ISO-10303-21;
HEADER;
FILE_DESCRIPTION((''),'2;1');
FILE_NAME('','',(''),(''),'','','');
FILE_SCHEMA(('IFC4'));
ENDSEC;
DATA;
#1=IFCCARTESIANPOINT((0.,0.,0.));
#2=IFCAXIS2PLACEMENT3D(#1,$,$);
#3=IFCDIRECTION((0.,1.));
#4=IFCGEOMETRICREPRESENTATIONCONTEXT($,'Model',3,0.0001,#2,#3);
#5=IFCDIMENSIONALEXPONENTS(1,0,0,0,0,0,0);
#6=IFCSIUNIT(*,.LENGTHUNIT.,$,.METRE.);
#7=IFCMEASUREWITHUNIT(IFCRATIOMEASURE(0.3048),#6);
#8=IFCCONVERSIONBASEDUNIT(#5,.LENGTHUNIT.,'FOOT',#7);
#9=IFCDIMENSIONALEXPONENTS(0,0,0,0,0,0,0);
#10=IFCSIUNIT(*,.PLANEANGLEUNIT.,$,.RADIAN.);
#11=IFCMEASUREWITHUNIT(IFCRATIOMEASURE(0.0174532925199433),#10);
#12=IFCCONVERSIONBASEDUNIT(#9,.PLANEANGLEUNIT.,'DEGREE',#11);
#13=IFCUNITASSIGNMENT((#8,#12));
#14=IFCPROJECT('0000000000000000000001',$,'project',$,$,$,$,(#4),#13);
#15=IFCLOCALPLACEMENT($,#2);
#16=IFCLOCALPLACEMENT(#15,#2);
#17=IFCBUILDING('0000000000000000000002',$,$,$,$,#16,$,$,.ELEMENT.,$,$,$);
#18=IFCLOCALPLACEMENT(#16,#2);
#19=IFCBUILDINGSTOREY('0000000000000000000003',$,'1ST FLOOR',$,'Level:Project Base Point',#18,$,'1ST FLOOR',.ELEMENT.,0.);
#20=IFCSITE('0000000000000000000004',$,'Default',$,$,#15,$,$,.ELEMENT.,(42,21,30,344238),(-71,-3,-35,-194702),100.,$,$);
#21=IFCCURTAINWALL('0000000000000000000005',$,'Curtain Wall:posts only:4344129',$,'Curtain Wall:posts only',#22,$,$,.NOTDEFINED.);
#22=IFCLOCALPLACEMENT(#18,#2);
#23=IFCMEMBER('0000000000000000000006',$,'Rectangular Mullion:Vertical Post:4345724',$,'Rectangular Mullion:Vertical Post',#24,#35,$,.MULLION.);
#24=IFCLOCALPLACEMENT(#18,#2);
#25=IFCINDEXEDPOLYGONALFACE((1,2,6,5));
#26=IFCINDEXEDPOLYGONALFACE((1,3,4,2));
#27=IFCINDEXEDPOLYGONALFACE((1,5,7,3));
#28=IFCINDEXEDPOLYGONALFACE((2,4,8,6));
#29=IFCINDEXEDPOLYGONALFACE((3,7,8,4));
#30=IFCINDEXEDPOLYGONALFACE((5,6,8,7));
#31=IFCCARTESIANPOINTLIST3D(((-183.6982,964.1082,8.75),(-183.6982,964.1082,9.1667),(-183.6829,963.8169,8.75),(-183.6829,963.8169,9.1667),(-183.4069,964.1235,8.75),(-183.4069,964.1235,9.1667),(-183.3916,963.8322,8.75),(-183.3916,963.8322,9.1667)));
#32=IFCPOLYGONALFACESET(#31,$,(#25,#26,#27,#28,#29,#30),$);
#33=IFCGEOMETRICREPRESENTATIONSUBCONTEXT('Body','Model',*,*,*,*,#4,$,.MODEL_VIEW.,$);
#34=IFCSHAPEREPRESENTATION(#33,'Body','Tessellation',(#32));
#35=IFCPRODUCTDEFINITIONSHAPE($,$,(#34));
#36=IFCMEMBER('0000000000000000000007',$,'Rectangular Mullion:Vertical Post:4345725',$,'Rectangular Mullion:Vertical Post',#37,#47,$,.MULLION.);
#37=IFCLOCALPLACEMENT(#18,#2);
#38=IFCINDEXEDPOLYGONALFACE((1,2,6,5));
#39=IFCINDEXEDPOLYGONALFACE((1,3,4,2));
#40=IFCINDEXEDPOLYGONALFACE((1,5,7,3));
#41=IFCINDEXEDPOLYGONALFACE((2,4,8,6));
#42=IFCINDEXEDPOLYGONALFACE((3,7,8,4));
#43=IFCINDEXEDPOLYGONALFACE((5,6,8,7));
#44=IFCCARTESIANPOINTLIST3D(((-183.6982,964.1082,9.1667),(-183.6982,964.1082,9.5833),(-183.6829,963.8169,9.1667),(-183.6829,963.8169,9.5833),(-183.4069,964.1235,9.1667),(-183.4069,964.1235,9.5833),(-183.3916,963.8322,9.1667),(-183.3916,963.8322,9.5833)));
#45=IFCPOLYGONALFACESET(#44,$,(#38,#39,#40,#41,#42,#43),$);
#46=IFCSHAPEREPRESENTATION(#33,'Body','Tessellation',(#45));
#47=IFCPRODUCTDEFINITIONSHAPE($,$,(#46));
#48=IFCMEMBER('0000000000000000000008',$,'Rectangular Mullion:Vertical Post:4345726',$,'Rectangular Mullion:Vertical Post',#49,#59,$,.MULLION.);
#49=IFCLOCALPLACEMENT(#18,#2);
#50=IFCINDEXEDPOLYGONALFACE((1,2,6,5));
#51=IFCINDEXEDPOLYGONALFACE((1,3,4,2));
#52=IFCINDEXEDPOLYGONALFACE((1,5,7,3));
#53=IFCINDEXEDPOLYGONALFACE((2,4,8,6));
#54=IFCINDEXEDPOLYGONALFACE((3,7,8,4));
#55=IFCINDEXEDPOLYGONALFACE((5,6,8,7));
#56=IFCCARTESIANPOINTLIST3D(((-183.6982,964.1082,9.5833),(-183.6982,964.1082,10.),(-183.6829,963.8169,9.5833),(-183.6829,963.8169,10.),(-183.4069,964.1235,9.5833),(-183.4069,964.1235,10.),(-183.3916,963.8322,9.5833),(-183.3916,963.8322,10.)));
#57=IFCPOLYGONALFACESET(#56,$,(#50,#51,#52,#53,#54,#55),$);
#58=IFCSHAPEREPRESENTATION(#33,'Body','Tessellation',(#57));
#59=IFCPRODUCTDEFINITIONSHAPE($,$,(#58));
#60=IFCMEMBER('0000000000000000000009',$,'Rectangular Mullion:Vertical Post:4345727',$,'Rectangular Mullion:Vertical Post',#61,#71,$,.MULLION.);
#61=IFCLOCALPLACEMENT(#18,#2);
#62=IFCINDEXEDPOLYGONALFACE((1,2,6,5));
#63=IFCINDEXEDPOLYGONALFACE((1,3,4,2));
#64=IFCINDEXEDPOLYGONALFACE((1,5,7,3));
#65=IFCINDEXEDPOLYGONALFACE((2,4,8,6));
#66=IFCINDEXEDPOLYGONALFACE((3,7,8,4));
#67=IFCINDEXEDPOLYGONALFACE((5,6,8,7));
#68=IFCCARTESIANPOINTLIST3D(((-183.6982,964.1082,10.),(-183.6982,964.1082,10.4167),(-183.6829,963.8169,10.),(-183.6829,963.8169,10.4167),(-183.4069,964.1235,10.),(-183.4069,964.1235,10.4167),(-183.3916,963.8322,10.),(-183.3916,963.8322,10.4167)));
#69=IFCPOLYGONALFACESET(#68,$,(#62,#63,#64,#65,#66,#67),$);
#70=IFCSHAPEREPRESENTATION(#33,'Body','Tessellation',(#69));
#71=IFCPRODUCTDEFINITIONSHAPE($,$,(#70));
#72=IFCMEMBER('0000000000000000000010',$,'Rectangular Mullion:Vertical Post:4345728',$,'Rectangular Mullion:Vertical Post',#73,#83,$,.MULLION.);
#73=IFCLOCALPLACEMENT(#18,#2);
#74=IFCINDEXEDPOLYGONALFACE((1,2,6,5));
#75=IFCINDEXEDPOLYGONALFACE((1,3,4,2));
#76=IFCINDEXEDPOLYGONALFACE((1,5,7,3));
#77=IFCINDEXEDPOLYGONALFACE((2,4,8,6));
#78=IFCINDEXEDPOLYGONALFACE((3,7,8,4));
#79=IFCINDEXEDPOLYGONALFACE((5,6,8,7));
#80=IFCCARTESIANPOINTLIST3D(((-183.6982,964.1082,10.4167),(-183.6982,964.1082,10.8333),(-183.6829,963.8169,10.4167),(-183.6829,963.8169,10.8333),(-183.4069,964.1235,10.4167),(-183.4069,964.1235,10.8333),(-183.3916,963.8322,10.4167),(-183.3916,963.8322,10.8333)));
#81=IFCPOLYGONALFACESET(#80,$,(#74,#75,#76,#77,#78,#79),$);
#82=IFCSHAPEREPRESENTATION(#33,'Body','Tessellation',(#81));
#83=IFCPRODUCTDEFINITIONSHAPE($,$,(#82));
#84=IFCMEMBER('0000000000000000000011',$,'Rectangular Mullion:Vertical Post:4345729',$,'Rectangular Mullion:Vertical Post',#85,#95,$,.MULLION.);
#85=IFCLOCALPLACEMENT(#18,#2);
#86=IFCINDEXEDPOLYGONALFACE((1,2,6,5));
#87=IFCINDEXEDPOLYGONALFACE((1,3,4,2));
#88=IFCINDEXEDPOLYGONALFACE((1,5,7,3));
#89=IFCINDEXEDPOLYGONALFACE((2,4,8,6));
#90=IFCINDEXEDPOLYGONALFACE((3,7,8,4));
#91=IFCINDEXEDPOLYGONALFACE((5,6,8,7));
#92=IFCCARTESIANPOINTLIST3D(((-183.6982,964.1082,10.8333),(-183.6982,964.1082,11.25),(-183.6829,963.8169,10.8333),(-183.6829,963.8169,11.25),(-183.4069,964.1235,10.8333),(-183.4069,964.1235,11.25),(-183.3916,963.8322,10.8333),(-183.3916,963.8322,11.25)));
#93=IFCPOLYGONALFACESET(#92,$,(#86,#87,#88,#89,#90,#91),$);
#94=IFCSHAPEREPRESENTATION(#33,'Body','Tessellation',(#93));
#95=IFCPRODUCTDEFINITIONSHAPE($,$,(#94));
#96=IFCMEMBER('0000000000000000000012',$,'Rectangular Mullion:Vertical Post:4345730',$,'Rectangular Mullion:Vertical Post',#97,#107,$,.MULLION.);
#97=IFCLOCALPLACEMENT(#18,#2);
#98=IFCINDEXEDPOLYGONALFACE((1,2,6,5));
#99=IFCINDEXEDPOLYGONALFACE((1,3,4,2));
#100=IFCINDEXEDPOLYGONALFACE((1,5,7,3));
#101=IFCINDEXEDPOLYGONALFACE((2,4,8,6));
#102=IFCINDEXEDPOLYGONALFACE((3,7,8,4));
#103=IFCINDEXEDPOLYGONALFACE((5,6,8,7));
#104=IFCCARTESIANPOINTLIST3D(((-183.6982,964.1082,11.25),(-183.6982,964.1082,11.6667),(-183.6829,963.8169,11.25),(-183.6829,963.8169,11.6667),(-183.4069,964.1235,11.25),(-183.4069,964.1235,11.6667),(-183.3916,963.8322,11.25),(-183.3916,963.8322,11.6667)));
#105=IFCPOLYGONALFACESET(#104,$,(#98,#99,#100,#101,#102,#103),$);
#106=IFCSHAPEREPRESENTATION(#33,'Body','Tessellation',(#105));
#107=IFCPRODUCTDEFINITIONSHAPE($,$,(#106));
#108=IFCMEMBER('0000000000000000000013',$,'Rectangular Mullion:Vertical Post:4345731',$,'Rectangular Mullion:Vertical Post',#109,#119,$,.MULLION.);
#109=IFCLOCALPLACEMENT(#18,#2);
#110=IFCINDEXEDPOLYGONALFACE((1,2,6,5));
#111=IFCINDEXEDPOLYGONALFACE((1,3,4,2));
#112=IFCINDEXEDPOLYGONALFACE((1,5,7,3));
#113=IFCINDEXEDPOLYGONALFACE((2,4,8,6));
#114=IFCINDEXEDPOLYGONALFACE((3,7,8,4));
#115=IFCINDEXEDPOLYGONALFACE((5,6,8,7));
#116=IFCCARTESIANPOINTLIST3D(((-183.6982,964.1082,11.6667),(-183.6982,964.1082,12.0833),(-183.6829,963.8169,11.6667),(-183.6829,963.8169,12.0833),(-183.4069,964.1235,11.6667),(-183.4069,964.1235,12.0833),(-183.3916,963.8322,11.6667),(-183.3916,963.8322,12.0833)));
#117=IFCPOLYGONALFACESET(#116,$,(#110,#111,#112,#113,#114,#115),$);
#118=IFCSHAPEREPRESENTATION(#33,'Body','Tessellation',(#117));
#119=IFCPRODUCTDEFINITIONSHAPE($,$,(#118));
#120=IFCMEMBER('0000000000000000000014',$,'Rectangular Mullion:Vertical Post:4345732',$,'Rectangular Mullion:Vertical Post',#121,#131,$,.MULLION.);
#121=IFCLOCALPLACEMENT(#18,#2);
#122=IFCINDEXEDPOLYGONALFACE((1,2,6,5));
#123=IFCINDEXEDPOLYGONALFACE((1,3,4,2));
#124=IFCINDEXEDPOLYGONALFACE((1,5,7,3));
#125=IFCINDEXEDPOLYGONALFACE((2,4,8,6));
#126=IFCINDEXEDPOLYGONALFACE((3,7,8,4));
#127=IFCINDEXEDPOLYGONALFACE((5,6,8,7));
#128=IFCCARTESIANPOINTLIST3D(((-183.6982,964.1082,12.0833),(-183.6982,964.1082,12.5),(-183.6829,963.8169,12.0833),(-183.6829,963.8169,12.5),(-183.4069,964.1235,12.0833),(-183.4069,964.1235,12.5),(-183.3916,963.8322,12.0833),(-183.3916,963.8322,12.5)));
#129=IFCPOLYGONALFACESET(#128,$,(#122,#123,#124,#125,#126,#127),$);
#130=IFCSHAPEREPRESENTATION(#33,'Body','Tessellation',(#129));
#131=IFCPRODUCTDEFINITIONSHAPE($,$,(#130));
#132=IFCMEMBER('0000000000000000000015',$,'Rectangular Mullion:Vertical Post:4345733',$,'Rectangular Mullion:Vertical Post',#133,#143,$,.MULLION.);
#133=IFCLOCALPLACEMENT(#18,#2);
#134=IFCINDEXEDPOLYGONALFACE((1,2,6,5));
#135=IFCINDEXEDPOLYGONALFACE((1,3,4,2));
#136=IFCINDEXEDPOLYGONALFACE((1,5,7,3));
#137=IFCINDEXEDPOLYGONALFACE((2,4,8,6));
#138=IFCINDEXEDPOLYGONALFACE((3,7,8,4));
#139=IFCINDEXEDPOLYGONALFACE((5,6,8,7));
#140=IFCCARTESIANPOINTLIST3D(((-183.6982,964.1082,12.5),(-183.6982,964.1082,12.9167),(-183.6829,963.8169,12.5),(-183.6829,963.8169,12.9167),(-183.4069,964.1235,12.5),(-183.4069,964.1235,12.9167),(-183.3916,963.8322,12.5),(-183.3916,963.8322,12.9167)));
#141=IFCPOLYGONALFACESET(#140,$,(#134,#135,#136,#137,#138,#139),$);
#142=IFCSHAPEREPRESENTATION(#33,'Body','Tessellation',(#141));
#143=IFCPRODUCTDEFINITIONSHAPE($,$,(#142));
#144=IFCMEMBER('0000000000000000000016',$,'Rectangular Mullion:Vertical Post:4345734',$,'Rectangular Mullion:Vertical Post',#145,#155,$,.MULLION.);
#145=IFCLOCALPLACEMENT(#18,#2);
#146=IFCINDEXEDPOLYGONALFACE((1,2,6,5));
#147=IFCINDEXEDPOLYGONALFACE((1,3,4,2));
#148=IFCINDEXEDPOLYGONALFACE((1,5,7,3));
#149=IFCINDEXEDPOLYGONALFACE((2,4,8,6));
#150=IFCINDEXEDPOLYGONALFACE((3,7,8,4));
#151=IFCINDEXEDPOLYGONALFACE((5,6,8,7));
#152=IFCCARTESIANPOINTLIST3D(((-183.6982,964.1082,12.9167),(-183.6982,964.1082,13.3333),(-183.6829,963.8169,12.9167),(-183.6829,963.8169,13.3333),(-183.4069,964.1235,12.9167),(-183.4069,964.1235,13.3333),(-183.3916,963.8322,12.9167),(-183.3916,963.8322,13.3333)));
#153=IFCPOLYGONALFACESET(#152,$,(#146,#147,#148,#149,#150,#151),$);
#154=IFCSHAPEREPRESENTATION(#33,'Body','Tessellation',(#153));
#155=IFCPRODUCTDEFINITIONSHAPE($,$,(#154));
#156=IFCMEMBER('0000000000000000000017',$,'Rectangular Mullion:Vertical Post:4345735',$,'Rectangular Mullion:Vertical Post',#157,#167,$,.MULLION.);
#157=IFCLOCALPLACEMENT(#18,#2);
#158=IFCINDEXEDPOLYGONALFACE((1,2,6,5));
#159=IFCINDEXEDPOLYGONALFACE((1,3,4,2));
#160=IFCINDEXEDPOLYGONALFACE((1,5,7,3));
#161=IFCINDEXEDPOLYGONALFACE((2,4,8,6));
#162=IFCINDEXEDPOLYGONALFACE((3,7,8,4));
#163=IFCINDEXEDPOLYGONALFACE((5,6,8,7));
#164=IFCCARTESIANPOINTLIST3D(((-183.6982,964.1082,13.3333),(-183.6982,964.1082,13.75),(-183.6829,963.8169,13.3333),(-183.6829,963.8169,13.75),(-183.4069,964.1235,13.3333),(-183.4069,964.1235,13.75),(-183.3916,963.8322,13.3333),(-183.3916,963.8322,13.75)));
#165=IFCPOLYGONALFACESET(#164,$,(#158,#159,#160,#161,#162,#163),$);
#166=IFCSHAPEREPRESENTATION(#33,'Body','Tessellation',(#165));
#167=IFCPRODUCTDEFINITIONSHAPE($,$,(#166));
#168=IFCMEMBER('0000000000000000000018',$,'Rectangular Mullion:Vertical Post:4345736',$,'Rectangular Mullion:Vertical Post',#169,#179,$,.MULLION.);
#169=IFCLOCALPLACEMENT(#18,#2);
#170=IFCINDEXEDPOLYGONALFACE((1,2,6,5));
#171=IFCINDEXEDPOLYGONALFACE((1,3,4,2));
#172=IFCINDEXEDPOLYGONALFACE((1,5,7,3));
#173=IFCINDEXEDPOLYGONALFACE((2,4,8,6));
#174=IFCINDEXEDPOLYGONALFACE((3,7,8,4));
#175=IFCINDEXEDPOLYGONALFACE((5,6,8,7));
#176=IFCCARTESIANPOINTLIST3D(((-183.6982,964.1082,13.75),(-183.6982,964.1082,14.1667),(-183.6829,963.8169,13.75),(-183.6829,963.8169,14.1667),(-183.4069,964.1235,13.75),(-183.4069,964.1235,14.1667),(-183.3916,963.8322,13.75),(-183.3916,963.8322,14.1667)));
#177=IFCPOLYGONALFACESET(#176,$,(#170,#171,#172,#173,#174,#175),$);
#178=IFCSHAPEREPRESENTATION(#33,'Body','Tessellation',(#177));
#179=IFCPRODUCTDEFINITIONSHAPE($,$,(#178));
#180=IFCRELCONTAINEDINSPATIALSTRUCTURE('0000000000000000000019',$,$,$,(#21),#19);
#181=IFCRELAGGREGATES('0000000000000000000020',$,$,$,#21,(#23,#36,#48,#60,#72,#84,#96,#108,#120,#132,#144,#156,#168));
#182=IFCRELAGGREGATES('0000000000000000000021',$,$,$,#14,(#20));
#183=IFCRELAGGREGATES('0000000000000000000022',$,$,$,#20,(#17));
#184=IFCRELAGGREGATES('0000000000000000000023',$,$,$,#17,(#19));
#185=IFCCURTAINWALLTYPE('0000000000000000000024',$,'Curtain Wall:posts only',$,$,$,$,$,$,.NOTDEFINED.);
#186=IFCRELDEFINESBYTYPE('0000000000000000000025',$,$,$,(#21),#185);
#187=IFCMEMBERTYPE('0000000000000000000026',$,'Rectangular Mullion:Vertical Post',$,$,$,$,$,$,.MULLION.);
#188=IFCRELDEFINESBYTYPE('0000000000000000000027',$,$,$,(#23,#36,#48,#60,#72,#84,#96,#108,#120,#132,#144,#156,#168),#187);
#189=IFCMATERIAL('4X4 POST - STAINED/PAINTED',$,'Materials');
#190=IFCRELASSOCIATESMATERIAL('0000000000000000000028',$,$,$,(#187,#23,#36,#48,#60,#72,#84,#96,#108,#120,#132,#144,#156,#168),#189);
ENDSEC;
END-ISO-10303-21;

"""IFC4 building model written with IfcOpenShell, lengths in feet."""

from ifc_helpers import new_model, entity, si_unit, converted_unit, direction, frame, origin, origin_2d_with_axis, place, context, subcontext, project, spatial, rectangle, extrude, source, transform, mapped, material, material_profile, profile_set, profile_usage, type_object, type_shapes, element, aggregate, save


model = new_model("IFC4")

# Units and contexts
model_context = context("Model", 3, precision=0.0001, world=origin(), true_north=direction((0.0, 1.0)))
body_context = subcontext(model_context, "Body", "Model", "MODEL_VIEW")
ifc_project = project(units=[converted_unit("LENGTHUNIT", "FOOT", entity("IfcRatioMeasure", 0.3048), si_unit("LENGTHUNIT", "METRE"), dimensions=[1, 0, 0, 0, 0, 0, 0]), converted_unit("PLANEANGLEUNIT", "DEGREE", entity("IfcRatioMeasure", 0.0174532925199433), si_unit("PLANEANGLEUNIT", "RADIAN"), dimensions=[0, 0, 0, 0, 0, 0, 0])], contexts=[model_context])

# Site, building, storey
site_placement = place(None, origin())
site = spatial("IfcSite", under=ifc_project, at=site_placement, Name="Default", CompositionType="ELEMENT", RefLatitude=(42, 21, 30, 344238), RefLongitude=(-71, -3, -35, -194702), RefElevation=100.0)
building_placement = place(site_placement, origin())
building = spatial("IfcBuilding", under=site, at=building_placement, CompositionType="ELEMENT")
storey_placement = place(building_placement, origin())
storey = spatial("IfcBuildingStorey", under=building, at=storey_placement, Name="1ST FLOOR", ObjectType="Level:Project Base Point", LongName="1ST FLOOR", CompositionType="ELEMENT", Elevation=0.0)

# Curtain wall, members
curtain_wall_type_1 = type_object("IfcCurtainWallType", Name="Curtain Wall:posts only", PredefinedType="NOTDEFINED")
curtain_wall_1_placement = place(storey_placement, origin())
curtain_wall_1 = element("IfcCurtainWall", 1, at=curtain_wall_1_placement, inside=storey, type_object=curtain_wall_type_1, Name="Curtain Wall:posts only:4344129", ObjectType="Curtain Wall:posts only", PredefinedType="NOTDEFINED")
ifc_material_1 = material(Name="4X4 POST - STAINED/PAINTED", Category="Materials")
ifc_material_profile_1 = material_profile(ifc_material_1, rectangle(XDim=0.2917, YDim=0.2917, at=origin_2d_with_axis()), Name="Vertical Post")
ifc_profile_set_1 = profile_set([ifc_material_profile_1], Name="Vertical Post")
ifc_profile_usage_1 = profile_usage(ifc_profile_set_1)
member_type_1 = type_object("IfcMemberType", Name="Rectangular Mullion:Vertical Post", PredefinedType="MULLION", material=ifc_profile_set_1)
shared_shape_1 = source(origin(), body_context, "Body", "SweptSolid", [
    extrude(rectangle(XDim=0.2917, YDim=0.2917, at=origin_2d_with_axis()), frame((0.0, -0.2083, -0.4167), z_axis=(0.0, 0.0, 1.0), x_axis=(0.0, -1.0, 0.0)), (0.0, 0.0, 1.0), 0.4167),
])
type_shapes(member_type_1, [shared_shape_1])
member_1_placement = place(storey_placement, frame((-183.5558, 964.1782, 8.75), z_axis=(0.0, 0.0, -1.0), x_axis=(-0.99863, -0.052336, 0.0)))
member_1 = element("IfcMember", 2, at=member_1_placement, type_object=member_type_1, material=ifc_profile_usage_1, Name="Rectangular Mullion:Vertical Post:4345724", ObjectType="Rectangular Mullion:Vertical Post", PredefinedType="MULLION", context=body_context, shape_type="MappedRepresentation", body=[
    mapped(shared_shape_1, transform((0.0, 0.0, 0.0), scale=1.0)),
])
ifc_profile_usage_2 = profile_usage(ifc_profile_set_1)
member_2_placement = place(storey_placement, frame((-183.5558, 964.1782, 9.1667), z_axis=(0.0, 0.0, -1.0), x_axis=(-0.99863, -0.052336, 0.0)))
member_2 = element("IfcMember", 3, at=member_2_placement, type_object=member_type_1, material=ifc_profile_usage_2, Name="Rectangular Mullion:Vertical Post:4345725", ObjectType="Rectangular Mullion:Vertical Post", PredefinedType="MULLION", context=body_context, shape_type="MappedRepresentation", body=[
    mapped(shared_shape_1, transform((0.0, 0.0, 0.0), scale=1.0)),
])
ifc_profile_usage_3 = profile_usage(ifc_profile_set_1)
member_3_placement = place(storey_placement, frame((-183.5558, 964.1782, 9.5833), z_axis=(0.0, 0.0, -1.0), x_axis=(-0.99863, -0.052336, 0.0)))
member_3 = element("IfcMember", 4, at=member_3_placement, type_object=member_type_1, material=ifc_profile_usage_3, Name="Rectangular Mullion:Vertical Post:4345726", ObjectType="Rectangular Mullion:Vertical Post", PredefinedType="MULLION", context=body_context, shape_type="MappedRepresentation", body=[
    mapped(shared_shape_1, transform((0.0, 0.0, 0.0), scale=1.0)),
])
ifc_profile_usage_4 = profile_usage(ifc_profile_set_1)
member_4_placement = place(storey_placement, frame((-183.5558, 964.1782, 10.0), z_axis=(0.0, 0.0, -1.0), x_axis=(-0.99863, -0.052336, 0.0)))
member_4 = element("IfcMember", 5, at=member_4_placement, type_object=member_type_1, material=ifc_profile_usage_4, Name="Rectangular Mullion:Vertical Post:4345727", ObjectType="Rectangular Mullion:Vertical Post", PredefinedType="MULLION", context=body_context, shape_type="MappedRepresentation", body=[
    mapped(shared_shape_1, transform((0.0, 0.0, 0.0), scale=1.0)),
])
ifc_profile_usage_5 = profile_usage(ifc_profile_set_1)
member_5_placement = place(storey_placement, frame((-183.5558, 964.1782, 10.4167), z_axis=(0.0, 0.0, -1.0), x_axis=(-0.99863, -0.052336, 0.0)))
member_5 = element("IfcMember", 6, at=member_5_placement, type_object=member_type_1, material=ifc_profile_usage_5, Name="Rectangular Mullion:Vertical Post:4345728", ObjectType="Rectangular Mullion:Vertical Post", PredefinedType="MULLION", context=body_context, shape_type="MappedRepresentation", body=[
    mapped(shared_shape_1, transform((0.0, 0.0, 0.0), scale=1.0)),
])
ifc_profile_usage_6 = profile_usage(ifc_profile_set_1)
member_6_placement = place(storey_placement, frame((-183.5558, 964.1782, 10.8333), z_axis=(0.0, 0.0, -1.0), x_axis=(-0.99863, -0.052336, 0.0)))
member_6 = element("IfcMember", 7, at=member_6_placement, type_object=member_type_1, material=ifc_profile_usage_6, Name="Rectangular Mullion:Vertical Post:4345729", ObjectType="Rectangular Mullion:Vertical Post", PredefinedType="MULLION", context=body_context, shape_type="MappedRepresentation", body=[
    mapped(shared_shape_1, transform((0.0, 0.0, 0.0), scale=1.0)),
])
ifc_profile_usage_7 = profile_usage(ifc_profile_set_1)
member_7_placement = place(storey_placement, frame((-183.5558, 964.1782, 11.25), z_axis=(0.0, 0.0, -1.0), x_axis=(-0.99863, -0.052336, 0.0)))
member_7 = element("IfcMember", 8, at=member_7_placement, type_object=member_type_1, material=ifc_profile_usage_7, Name="Rectangular Mullion:Vertical Post:4345730", ObjectType="Rectangular Mullion:Vertical Post", PredefinedType="MULLION", context=body_context, shape_type="MappedRepresentation", body=[
    mapped(shared_shape_1, transform((0.0, 0.0, 0.0), scale=1.0)),
])
ifc_profile_usage_8 = profile_usage(ifc_profile_set_1)
member_8_placement = place(storey_placement, frame((-183.5558, 964.1782, 11.6667), z_axis=(0.0, 0.0, -1.0), x_axis=(-0.99863, -0.052336, 0.0)))
member_8 = element("IfcMember", 9, at=member_8_placement, type_object=member_type_1, material=ifc_profile_usage_8, Name="Rectangular Mullion:Vertical Post:4345731", ObjectType="Rectangular Mullion:Vertical Post", PredefinedType="MULLION", context=body_context, shape_type="MappedRepresentation", body=[
    mapped(shared_shape_1, transform((0.0, 0.0, 0.0), scale=1.0)),
])
ifc_profile_usage_9 = profile_usage(ifc_profile_set_1)
member_9_placement = place(storey_placement, frame((-183.5558, 964.1782, 12.0833), z_axis=(0.0, 0.0, -1.0), x_axis=(-0.99863, -0.052336, 0.0)))
member_9 = element("IfcMember", 10, at=member_9_placement, type_object=member_type_1, material=ifc_profile_usage_9, Name="Rectangular Mullion:Vertical Post:4345732", ObjectType="Rectangular Mullion:Vertical Post", PredefinedType="MULLION", context=body_context, shape_type="MappedRepresentation", body=[
    mapped(shared_shape_1, transform((0.0, 0.0, 0.0), scale=1.0)),
])
ifc_profile_usage_10 = profile_usage(ifc_profile_set_1)
member_10_placement = place(storey_placement, frame((-183.5558, 964.1782, 12.5), z_axis=(0.0, 0.0, -1.0), x_axis=(-0.99863, -0.052336, 0.0)))
member_10 = element("IfcMember", 11, at=member_10_placement, type_object=member_type_1, material=ifc_profile_usage_10, Name="Rectangular Mullion:Vertical Post:4345733", ObjectType="Rectangular Mullion:Vertical Post", PredefinedType="MULLION", context=body_context, shape_type="MappedRepresentation", body=[
    mapped(shared_shape_1, transform((0.0, 0.0, 0.0), scale=1.0)),
])
ifc_profile_usage_11 = profile_usage(ifc_profile_set_1)
member_11_placement = place(storey_placement, frame((-183.5558, 964.1782, 12.9167), z_axis=(0.0, 0.0, -1.0), x_axis=(-0.99863, -0.052336, 0.0)))
member_11 = element("IfcMember", 12, at=member_11_placement, type_object=member_type_1, material=ifc_profile_usage_11, Name="Rectangular Mullion:Vertical Post:4345734", ObjectType="Rectangular Mullion:Vertical Post", PredefinedType="MULLION", context=body_context, shape_type="MappedRepresentation", body=[
    mapped(shared_shape_1, transform((0.0, 0.0, 0.0), scale=1.0)),
])
ifc_profile_usage_12 = profile_usage(ifc_profile_set_1)
member_12_placement = place(storey_placement, frame((-183.5558, 964.1782, 13.3333), z_axis=(0.0, 0.0, -1.0), x_axis=(-0.99863, -0.052336, 0.0)))
member_12 = element("IfcMember", 13, at=member_12_placement, type_object=member_type_1, material=ifc_profile_usage_12, Name="Rectangular Mullion:Vertical Post:4345735", ObjectType="Rectangular Mullion:Vertical Post", PredefinedType="MULLION", context=body_context, shape_type="MappedRepresentation", body=[
    mapped(shared_shape_1, transform((0.0, 0.0, 0.0), scale=1.0)),
])
ifc_profile_usage_13 = profile_usage(ifc_profile_set_1)
member_13_placement = place(storey_placement, frame((-183.5558, 964.1782, 13.75), z_axis=(0.0, 0.0, -1.0), x_axis=(-0.99863, -0.052336, 0.0)))
member_13 = element("IfcMember", 14, at=member_13_placement, type_object=member_type_1, material=ifc_profile_usage_13, Name="Rectangular Mullion:Vertical Post:4345736", ObjectType="Rectangular Mullion:Vertical Post", PredefinedType="MULLION", context=body_context, shape_type="MappedRepresentation", body=[
    mapped(shared_shape_1, transform((0.0, 0.0, 0.0), scale=1.0)),
])
aggregate(curtain_wall_1, [member_1, member_2, member_3, member_4, member_5, member_6, member_7, member_8, member_9, member_10, member_11, member_12, member_13])

save(model, "model.ifc")
